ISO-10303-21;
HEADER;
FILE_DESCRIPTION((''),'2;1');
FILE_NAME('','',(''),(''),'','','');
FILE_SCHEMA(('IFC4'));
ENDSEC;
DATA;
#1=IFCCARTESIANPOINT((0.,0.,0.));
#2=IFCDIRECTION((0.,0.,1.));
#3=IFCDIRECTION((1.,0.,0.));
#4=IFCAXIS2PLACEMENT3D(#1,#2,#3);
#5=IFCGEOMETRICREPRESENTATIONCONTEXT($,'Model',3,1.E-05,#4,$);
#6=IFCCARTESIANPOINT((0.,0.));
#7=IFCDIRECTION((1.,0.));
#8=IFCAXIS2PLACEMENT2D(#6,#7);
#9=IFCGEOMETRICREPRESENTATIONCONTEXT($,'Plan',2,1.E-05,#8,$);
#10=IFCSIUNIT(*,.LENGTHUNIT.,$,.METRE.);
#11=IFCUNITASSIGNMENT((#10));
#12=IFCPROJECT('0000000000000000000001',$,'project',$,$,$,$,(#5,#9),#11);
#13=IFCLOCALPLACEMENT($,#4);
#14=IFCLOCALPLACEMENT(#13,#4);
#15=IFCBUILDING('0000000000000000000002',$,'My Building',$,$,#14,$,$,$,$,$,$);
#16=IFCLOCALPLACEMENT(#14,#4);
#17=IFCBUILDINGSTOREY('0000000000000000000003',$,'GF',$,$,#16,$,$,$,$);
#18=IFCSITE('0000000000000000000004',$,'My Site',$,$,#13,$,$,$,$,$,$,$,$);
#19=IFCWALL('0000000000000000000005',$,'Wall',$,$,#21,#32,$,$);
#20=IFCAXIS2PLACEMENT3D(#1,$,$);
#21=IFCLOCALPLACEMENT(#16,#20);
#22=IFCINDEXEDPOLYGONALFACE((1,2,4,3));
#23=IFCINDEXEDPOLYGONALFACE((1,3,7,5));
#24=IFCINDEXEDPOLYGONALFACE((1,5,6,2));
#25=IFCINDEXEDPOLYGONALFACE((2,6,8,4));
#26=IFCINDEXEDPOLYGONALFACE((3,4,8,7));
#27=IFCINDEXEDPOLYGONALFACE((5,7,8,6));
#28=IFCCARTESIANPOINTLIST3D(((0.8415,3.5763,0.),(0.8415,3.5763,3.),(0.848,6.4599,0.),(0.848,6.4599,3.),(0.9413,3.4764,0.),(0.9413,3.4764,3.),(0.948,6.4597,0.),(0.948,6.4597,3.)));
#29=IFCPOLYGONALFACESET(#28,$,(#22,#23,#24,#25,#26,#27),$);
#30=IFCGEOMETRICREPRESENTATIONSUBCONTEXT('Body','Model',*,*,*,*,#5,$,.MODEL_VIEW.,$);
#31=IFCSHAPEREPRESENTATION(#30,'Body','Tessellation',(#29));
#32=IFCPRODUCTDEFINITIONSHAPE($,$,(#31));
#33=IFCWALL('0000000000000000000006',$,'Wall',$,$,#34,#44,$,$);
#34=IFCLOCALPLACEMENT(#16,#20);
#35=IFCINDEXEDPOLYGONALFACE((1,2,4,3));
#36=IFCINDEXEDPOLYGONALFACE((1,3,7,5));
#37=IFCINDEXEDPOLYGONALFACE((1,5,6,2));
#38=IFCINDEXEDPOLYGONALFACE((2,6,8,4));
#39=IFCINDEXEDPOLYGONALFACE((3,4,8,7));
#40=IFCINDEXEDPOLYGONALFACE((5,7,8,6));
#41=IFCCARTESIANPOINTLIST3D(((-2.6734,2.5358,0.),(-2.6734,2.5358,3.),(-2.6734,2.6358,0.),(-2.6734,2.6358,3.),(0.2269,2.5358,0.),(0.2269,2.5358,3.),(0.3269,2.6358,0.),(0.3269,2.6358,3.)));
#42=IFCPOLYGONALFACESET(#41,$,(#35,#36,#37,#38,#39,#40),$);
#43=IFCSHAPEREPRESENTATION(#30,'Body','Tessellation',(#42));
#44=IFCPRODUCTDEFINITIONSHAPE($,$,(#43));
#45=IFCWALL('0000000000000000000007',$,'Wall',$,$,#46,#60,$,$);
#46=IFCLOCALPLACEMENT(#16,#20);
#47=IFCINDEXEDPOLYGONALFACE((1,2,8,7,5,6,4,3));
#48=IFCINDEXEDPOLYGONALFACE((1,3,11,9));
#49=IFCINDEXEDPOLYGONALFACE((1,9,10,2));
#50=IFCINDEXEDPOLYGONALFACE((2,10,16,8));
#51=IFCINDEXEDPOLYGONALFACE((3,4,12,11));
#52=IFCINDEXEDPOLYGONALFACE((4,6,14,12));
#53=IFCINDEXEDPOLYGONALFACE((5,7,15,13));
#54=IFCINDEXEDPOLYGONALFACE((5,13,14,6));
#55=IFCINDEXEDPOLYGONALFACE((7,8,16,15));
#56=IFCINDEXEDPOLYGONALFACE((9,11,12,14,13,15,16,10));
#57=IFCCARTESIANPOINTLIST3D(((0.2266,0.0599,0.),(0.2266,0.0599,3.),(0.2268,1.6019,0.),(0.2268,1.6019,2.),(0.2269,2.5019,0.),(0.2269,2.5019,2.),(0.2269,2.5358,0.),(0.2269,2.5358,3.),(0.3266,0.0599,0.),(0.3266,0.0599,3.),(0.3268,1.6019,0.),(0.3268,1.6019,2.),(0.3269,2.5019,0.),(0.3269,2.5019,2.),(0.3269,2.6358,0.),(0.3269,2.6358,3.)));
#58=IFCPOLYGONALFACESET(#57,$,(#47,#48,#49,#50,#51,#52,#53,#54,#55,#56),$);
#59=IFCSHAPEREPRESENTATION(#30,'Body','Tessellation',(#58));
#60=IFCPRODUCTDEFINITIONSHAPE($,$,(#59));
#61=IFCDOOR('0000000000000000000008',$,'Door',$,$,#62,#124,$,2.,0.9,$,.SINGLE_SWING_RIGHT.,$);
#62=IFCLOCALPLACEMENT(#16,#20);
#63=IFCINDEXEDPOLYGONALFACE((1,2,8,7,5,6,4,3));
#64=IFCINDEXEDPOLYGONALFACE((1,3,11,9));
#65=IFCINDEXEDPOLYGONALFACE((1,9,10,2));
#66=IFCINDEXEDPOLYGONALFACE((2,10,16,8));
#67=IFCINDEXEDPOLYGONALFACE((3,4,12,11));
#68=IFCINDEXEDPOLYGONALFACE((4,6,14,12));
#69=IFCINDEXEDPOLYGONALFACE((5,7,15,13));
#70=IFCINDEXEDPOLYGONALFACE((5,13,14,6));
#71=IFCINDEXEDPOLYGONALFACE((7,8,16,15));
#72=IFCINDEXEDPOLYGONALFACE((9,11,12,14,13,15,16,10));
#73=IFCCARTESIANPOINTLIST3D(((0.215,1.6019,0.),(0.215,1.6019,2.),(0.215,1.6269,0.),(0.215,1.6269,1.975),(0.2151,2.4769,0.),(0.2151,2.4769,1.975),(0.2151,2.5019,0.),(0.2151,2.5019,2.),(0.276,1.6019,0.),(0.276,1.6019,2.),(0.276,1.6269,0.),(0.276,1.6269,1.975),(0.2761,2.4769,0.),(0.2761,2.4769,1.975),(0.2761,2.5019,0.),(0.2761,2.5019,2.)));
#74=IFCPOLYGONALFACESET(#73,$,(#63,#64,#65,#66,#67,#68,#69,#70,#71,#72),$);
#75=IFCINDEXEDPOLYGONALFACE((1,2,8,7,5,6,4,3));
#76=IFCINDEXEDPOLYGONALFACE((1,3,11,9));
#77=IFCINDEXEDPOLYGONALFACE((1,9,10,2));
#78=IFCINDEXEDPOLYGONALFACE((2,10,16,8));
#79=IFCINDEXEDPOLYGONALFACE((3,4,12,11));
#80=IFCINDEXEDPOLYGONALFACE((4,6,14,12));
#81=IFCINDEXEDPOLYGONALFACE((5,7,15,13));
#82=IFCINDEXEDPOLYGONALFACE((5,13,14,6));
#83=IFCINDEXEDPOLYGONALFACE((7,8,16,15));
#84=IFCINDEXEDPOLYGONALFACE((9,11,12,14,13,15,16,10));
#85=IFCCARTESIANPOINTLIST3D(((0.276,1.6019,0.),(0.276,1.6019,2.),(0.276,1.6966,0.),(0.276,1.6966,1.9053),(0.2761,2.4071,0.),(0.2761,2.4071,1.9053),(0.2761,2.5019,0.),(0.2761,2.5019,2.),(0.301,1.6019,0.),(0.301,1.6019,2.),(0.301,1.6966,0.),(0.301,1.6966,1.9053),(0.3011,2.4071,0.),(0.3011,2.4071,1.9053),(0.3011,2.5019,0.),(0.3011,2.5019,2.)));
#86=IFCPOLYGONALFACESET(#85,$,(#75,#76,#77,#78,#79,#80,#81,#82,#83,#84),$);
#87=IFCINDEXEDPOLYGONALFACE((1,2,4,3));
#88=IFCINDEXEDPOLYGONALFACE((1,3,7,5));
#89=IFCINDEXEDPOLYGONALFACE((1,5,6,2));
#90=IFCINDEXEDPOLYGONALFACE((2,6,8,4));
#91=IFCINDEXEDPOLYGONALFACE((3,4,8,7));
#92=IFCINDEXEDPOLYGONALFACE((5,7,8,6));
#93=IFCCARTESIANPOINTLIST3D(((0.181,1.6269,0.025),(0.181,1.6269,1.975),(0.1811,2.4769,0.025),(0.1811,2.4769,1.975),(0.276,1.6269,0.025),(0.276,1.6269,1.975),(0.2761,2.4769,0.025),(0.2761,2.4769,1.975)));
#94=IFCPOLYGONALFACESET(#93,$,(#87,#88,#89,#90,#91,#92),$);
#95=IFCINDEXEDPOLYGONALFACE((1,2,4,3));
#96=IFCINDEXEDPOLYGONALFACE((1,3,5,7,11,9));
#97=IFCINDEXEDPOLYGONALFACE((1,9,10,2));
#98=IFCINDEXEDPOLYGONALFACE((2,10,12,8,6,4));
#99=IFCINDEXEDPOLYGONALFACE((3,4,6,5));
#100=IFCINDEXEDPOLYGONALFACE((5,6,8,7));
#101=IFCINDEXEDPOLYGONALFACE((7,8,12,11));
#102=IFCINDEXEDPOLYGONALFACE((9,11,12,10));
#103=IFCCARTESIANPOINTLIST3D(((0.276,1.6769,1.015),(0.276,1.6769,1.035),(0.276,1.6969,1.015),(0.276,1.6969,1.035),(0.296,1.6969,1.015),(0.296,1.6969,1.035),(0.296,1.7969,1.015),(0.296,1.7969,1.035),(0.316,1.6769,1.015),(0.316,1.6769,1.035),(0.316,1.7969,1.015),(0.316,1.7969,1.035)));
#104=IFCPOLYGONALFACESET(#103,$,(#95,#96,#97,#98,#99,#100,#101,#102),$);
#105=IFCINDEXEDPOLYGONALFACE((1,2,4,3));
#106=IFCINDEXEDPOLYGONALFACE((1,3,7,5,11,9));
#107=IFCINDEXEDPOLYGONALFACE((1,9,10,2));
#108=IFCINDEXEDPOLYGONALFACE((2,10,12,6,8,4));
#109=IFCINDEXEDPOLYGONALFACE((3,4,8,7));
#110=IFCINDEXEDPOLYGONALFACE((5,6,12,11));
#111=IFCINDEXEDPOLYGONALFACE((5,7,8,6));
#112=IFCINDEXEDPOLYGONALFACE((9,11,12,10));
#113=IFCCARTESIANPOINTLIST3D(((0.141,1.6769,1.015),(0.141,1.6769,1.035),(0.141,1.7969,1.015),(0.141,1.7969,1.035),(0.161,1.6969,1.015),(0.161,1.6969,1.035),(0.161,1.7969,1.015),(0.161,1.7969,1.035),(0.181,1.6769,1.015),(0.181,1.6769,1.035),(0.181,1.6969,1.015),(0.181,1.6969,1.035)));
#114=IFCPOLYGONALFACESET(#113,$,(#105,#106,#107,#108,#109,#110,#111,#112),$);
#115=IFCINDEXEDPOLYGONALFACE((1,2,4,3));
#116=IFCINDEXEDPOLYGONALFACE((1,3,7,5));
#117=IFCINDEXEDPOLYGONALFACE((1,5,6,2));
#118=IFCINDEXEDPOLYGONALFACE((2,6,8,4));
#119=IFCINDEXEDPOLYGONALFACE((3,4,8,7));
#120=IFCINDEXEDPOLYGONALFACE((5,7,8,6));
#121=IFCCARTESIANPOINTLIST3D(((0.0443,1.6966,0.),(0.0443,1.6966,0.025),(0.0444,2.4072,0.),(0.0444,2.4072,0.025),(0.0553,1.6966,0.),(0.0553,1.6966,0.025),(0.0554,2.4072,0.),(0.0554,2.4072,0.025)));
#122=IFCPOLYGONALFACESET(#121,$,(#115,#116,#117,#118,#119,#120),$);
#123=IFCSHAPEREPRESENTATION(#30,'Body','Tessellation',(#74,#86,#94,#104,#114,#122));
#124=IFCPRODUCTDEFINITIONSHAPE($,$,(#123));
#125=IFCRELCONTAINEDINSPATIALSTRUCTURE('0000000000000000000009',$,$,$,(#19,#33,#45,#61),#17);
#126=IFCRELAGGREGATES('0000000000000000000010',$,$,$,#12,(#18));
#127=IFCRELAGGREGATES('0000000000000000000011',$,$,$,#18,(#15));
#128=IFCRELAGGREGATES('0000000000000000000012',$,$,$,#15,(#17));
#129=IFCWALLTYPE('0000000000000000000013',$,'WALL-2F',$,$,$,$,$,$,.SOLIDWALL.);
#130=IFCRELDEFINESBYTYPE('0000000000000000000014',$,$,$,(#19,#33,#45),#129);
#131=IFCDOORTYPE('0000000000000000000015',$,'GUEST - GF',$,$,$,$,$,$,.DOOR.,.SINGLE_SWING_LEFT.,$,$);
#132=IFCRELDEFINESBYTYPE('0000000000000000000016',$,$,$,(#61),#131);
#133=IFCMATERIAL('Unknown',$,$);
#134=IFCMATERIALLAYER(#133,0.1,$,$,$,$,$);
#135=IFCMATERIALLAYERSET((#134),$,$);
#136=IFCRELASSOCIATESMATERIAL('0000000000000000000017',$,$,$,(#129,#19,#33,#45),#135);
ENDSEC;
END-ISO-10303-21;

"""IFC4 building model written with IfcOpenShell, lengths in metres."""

from ifc_helpers import new_model, entity, si_unit, frame, origin_with_axes, origin_2d_with_axis, place, context, subcontext, project, spatial, line, indexed_curve, outline, extrude, shape, source, transform, mapped, material, layer, layer_set, layer_usage, type_object, type_shapes, element, fill, save


model = new_model("IFC4")

# Units and contexts
model_context = context("Model", 3, precision=1e-05, world=origin_with_axes())
plan_context = context("Plan", 2, precision=1e-05, world=origin_2d_with_axis())
body_context_1 = subcontext(model_context, "Body", "Model", "MODEL_VIEW")
body_context_2 = subcontext(plan_context, "Body", "Plan", "PLAN_VIEW")
ifc_project = project(units=[si_unit("LENGTHUNIT", "METRE")], contexts=[model_context, plan_context])

# Site, building, storey
site_placement = place(None, origin_with_axes())
site = spatial("IfcSite", under=ifc_project, at=site_placement, Name="My Site")
building_placement = place(site_placement, origin_with_axes())
building = spatial("IfcBuilding", under=site, at=building_placement, Name="My Building")
storey_placement = place(building_placement, origin_with_axes())
storey = spatial("IfcBuildingStorey", under=building, at=storey_placement, Name="GF")

# Shared definitions
ifc_material = material(Name="Unknown")

# Shared definitions
ifc_layer_1 = layer(ifc_material, 0.1)
ifc_layer_set_1 = layer_set([ifc_layer_1])
wall_type = type_object("IfcWallType", Name="WALL-2F", PredefinedType="SOLIDWALL", material=ifc_layer_set_1)

# Walls
ifc_layer_usage_1 = layer_usage(ifc_layer_set_1, "AXIS2", "POSITIVE", 0.0)
wall_1_placement = place(storey_placement, frame((0.848, 6.4599, 0.0), z_axis=(0.0, 0.0, 1.0), x_axis=(-0.00226, -0.999997, 0.0)))
element("IfcWall", 1, at=wall_1_placement, inside=storey, type_object=wall_type, material=ifc_layer_usage_1, Name="Wall", context=body_context_1, shape_type="SweptSolid", body=[
    extrude(outline(indexed_curve([(0.0, 0.0), (0.0, 0.1), (2.9833, 0.1), (2.8836, 0.0)], segments=[line(1, 2, 3, 4, 1)])), origin_with_axes(), (0.0, 0.0, 1.0), 3.0),
])
ifc_layer_usage_2 = layer_usage(ifc_layer_set_1, "AXIS2", "POSITIVE", 0.0)
wall_2_placement = place(storey_placement, frame((-2.6734, 2.5358, 0.0), z_axis=(0.0, 0.0, 1.0), x_axis=(1.0, 0.0, 0.0)))
element("IfcWall", 2, at=wall_2_placement, inside=storey, type_object=wall_type, material=ifc_layer_usage_2, Name="Wall", context=body_context_1, shape_type="SweptSolid", body=[
    extrude(outline(indexed_curve([(0.0, 0.0), (0.0, 0.1), (3.0003, 0.1), (2.9003, 0.0)], segments=[line(1, 2, 3, 4, 1)])), origin_with_axes(), (0.0, 0.0, 1.0), 3.0),
])

# Wall, opening, door
ifc_layer_usage_3 = layer_usage(ifc_layer_set_1, "AXIS2", "POSITIVE", 0.0)
wall_3_placement = place(storey_placement, frame((0.2269, 2.5358, 0.0), z_axis=(0.0, 0.0, 1.0), x_axis=(-0.000105, -1.0, 0.0)))
wall_3 = element("IfcWall", 3, at=wall_3_placement, inside=storey, type_object=wall_type, material=ifc_layer_usage_3, Name="Wall", context=body_context_1, shape_type="SweptSolid", body=[
    extrude(outline(indexed_curve([(0.0, 0.0), (-0.1, 0.1), (2.4759, 0.1), (2.4759, 0.0)], segments=[line(1, 2, 3, 4, 1)])), origin_with_axes(), (0.0, 0.0, 1.0), 3.0),
])
shared_shape_1 = source(origin_with_axes(), body_context_1, "Body", "SweptSolid", [
    extrude(outline(indexed_curve([(0.0, 0.0), (0.9, 0.0), (0.9, 2.0), (0.0, 2.0)], segments=[line(1, 2, 3, 4, 1)])), frame((0.0, -0.6, 0.0), z_axis=(0.0, -1.0, 0.0), x_axis=(1.0, 0.0, 0.0)), (0.0, 0.0, -1.0), 1.2),
])
opening_1_placement = place(wall_3_placement, frame((0.9339, 0.2103, 0.0), z_axis=(0.0, 0.0, 1.0), x_axis=(-1.0, 0.0, 0.0)))
opening_1 = element("IfcOpeningElement", 4, at=opening_1_placement, cuts=wall_3, PredefinedType="OPENING", context=body_context_1, shape_type="MappedRepresentation", body=[
    mapped(shared_shape_1, transform((0.0, 0.0, 0.0), x_axis=(1.0, 0.0, 0.0), y_axis=(0.0, 1.0, 0.0), z_axis=(0.0, 0.0, 1.0), scale=1.0)),
])
door_type_1 = type_object("IfcDoorType", Name="GUEST - GF", OperationType="SINGLE_SWING_LEFT", PredefinedType="DOOR")
shared_shape_2 = source(origin_with_axes(), body_context_1, "Body", "SweptSolid", [
    extrude(outline(indexed_curve([(0.0, 0.0), (0.0, 2.0), (0.9, 2.0), (0.9, 0.0), (0.875, 0.0), (0.875, 1.975), (0.025, 1.975), (0.025, 0.0)], segments=[line(1, 2, 3, 4, 5, 6, 7, 8, 1)])), frame((0.0, 0.0093, 0.0), z_axis=(0.0, -1.0, 0.0), x_axis=(1.0, 0.0, 0.0)), (0.0, 0.0, -1.0), 0.061),
    extrude(outline(indexed_curve([(0.0, 0.0), (0.0, 2.0), (0.9, 2.0), (0.9, 0.0), (0.8053, 0.0), (0.8053, 1.9053), (0.0947, 1.9053), (0.0947, 0.0)], segments=[line(1, 2, 3, 4, 5, 6, 7, 8, 1)])), frame((0.0, -0.0157, 0.0), z_axis=(0.0, -1.0, 0.0), x_axis=(1.0, 0.0, 0.0)), (0.0, 0.0, -1.0), 0.025),
    extrude(outline(indexed_curve([(0.0, 0.0), (0.85, 0.0), (0.85, 0.095), (0.0, 0.095)], segments=[line(1, 2, 3, 4, 1)])), frame((0.025, 0.0093, 0.025), z_axis=(0.0, 0.0, 1.0), x_axis=(1.0, 0.0, 0.0)), (0.0, 0.0, 1.0), 1.95),
    extrude(outline(indexed_curve([(0.0, 0.0), (0.0, -0.04), (0.12, -0.04), (0.12, -0.02), (0.02, -0.02), (0.02, 0.0)], segments=[line(1, 2, 3, 4, 5, 6, 1)])), frame((0.075, 0.0093, 1.015), z_axis=(0.0, 0.0, 1.0), x_axis=(1.0, 0.0, 0.0)), (0.0, 0.0, 1.0), 0.02),
    extrude(outline(indexed_curve([(0.0, 0.0), (0.0, 0.04), (0.12, 0.04), (0.12, 0.02), (0.02, 0.02), (0.02, 0.0)], segments=[line(1, 2, 3, 4, 5, 6, 1)])), frame((0.075, 0.1043, 1.015), z_axis=(0.0, 0.0, 1.0), x_axis=(1.0, 0.0, 0.0)), (0.0, 0.0, 1.0), 0.02),
    extrude(outline(indexed_curve([(0.0, 0.0), (0.7105, 0.0), (0.7105, 0.011), (0.0, 0.011)], segments=[line(1, 2, 3, 4, 1)])), frame((0.0947, 0.23, 0.0), z_axis=(0.0, 0.0, 1.0), x_axis=(1.0, 0.0, 0.0)), (0.0, 0.0, 1.0), 0.025),
])
shared_shape_3 = source(origin_with_axes(), body_context_2, "Body", "Curve2D", [
    entity("IfcIndexedPolyCurve", entity("IfcCartesianPointList2D", [[0.0, -0.0157], [0.0, 0.0703], [0.025, 0.0703], [0.025, 0.0093], [0.0947, 0.0093], [0.0947, -0.0157]]), [entity("IfcLineIndex", [1, 2, 3, 4, 5, 6, 1])]),
    entity("IfcIndexedPolyCurve", entity("IfcCartesianPointList2D", [[0.9, -0.0157], [0.9, 0.0703], [0.875, 0.0703], [0.875, 0.0093], [0.8053, 0.0093], [0.8053, -0.0157]]), [entity("IfcLineIndex", [1, 2, 3, 4, 5, 6, 1])]),
    entity("IfcTrimmedCurve", entity("IfcEllipse", entity("IfcAxis2Placement2D", entity("IfcCartesianPoint", [0.78, 0.0703]), entity("IfcDirection", [1.0, 0.0])), 0.755, 0.85), [entity("IfcCartesianPoint", [0.78, 0.9203])], [entity("IfcCartesianPoint", [0.025, 0.0703])], True, "CARTESIAN"),
    entity("IfcIndexedPolyCurve", entity("IfcCartesianPointList2D", [[0.875, 0.0703], [0.78, 0.0703], [0.78, 0.9203], [0.875, 0.9203]]), [entity("IfcLineIndex", [1, 2, 3, 4, 1])]),
])
type_shapes(door_type_1, [shared_shape_2, shared_shape_3])
door_1_placement = place(opening_1_placement, frame((0.0, 0.1518, 0.0), z_axis=(0.0, 0.0, 1.0), x_axis=(1.0, 0.0, 0.0)))
door_1 = element("IfcDoor", 5, at=door_1_placement, inside=storey, type_object=door_type_1, Name="Door", OperationType="SINGLE_SWING_RIGHT", OverallHeight=2.0, OverallWidth=0.9, shapes=[
    shape(body_context_1, "Body", "MappedRepresentation", [mapped(shared_shape_2, transform((0.0, 0.0, 0.0), x_axis=(1.0, 0.0, 0.0), y_axis=(0.0, 1.0, 0.0), z_axis=(0.0, 0.0, 1.0), scale=1.0))]),
    shape(body_context_2, "Body", "MappedRepresentation", [mapped(shared_shape_3, transform((0.0, 0.0, 0.0), x_axis=(1.0, 0.0, 0.0), y_axis=(0.0, 1.0, 0.0), z_axis=(0.0, 0.0, 1.0), scale=1.0))]),
])
fill(opening_1, door_1)

save(model, "model.ifc")
